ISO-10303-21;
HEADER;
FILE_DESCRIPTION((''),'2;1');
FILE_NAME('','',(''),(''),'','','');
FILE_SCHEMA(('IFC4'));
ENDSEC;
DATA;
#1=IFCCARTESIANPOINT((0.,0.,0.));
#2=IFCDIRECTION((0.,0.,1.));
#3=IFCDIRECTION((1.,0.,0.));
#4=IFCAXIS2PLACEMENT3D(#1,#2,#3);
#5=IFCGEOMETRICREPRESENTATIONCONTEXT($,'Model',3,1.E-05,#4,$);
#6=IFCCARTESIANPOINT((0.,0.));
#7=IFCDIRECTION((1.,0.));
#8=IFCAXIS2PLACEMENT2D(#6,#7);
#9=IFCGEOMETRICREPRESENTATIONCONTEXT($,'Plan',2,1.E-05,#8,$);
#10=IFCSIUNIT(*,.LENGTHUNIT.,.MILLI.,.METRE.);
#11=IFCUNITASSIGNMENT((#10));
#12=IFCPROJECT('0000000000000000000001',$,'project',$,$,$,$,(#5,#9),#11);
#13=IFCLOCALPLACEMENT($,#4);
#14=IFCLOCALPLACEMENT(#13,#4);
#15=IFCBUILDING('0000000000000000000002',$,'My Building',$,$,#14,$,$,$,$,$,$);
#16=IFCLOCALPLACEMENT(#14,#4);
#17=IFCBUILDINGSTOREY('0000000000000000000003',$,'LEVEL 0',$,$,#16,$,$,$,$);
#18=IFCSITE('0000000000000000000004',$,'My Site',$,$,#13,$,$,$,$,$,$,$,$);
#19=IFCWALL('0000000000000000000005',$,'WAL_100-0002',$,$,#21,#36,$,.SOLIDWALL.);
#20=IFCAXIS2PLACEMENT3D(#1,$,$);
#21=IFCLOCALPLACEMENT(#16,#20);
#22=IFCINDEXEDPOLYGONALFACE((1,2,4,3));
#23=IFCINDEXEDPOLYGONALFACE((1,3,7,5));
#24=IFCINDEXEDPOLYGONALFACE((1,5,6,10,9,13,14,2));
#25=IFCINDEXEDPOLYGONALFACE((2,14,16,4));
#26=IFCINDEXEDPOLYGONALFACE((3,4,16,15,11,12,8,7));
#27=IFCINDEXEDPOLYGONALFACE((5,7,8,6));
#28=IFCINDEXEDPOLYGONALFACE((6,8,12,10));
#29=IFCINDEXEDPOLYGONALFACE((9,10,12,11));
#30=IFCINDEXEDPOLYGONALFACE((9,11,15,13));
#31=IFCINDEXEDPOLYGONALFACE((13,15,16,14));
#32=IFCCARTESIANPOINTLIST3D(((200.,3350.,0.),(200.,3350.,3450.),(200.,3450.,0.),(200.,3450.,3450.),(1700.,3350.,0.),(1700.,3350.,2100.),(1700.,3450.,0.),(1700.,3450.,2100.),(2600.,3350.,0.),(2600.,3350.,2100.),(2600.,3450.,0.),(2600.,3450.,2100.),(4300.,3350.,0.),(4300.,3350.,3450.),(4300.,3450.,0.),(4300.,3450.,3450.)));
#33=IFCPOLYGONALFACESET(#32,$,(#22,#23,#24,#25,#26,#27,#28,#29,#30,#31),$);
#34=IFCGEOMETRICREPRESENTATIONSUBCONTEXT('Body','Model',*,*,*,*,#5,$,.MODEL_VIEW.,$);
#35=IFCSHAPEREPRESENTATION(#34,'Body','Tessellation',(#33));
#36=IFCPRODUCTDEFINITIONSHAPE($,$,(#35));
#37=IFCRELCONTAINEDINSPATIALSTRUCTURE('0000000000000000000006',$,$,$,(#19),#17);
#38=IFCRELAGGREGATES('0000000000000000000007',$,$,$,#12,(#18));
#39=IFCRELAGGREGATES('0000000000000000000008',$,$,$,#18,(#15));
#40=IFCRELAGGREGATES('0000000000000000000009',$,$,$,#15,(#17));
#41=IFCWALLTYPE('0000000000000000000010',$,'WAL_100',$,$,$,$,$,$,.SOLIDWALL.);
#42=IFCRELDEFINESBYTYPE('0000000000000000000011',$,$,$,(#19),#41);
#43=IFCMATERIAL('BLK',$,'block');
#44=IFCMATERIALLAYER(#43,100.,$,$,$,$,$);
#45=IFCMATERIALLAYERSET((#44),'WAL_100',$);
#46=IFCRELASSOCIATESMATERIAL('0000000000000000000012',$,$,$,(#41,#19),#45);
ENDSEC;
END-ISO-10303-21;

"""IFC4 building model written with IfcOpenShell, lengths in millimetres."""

from ifc_helpers import new_model, si_unit, frame, origin_with_axes, origin_2d_with_axis, place, context, subcontext, project, spatial, indexed_curve, outline, extrude, material, layer, layer_set, layer_usage, type_object, element, save


model = new_model("IFC4")

# Units and contexts
model_context = context("Model", 3, precision=1e-05, world=origin_with_axes())
plan_context = context("Plan", 2, precision=1e-05, world=origin_2d_with_axis())
body_context = subcontext(model_context, "Body", "Model", "MODEL_VIEW")
ifc_project = project(units=[si_unit("LENGTHUNIT", "METRE", prefix="MILLI")], contexts=[model_context, plan_context])

# Site, building, storey
site_placement = place(None, origin_with_axes())
site = spatial("IfcSite", under=ifc_project, at=site_placement, Name="My Site")
building_placement = place(site_placement, origin_with_axes())
building = spatial("IfcBuilding", under=site, at=building_placement, Name="My Building")
storey_placement = place(building_placement, origin_with_axes())
storey = spatial("IfcBuildingStorey", under=building, at=storey_placement, Name="LEVEL 0")

# Shared definitions
ifc_material_1 = material(Name="BLK", Category="block")

# Wall, opening
ifc_layer_1 = layer(ifc_material_1, 100.0)
ifc_layer_set_1 = layer_set([ifc_layer_1], Name="WAL_100")
wall_type_1 = type_object("IfcWallType", Name="WAL_100", PredefinedType="SOLIDWALL", material=ifc_layer_set_1)
ifc_layer_usage_1 = layer_usage(ifc_layer_set_1, "AXIS2", "POSITIVE", 0.0)
wall_1_placement = place(storey_placement, frame((200.0, 3350.0, 0.0), z_axis=(0.0, 0.0, 1.0), x_axis=(1.0, 0.0, 0.0)))
wall_1 = element("IfcWall", 1, at=wall_1_placement, inside=storey, type_object=wall_type_1, material=ifc_layer_usage_1, Name="WAL_100-0002", PredefinedType="SOLIDWALL", context=body_context, shape_type="SweptSolid", body=[
    extrude(outline(indexed_curve([(0.0, 0.0), (0.0, 100.0), (4100.0, 100.0), (4100.0, 0.0), (0.0, 0.0)], self_intersect=False)), origin_with_axes(), (0.0, 0.0, 1.0), 3450.0),
])
opening_1_placement = place(wall_1_placement, frame((1500.0, 0.0, 0.0), z_axis=(0.0, 0.0, 1.0), x_axis=(1.0, 0.0, 0.0)))
element("IfcOpeningElement", 2, at=opening_1_placement, cuts=wall_1, PredefinedType="OPENING", context=body_context, shape_type="SweptSolid", body=[
    extrude(outline(indexed_curve([(0.0, 0.0), (0.0, 400.0), (900.0, 400.0), (900.0, 0.0), (0.0, 0.0)], self_intersect=False)), frame((0.0, -100.0, 0.0), z_axis=(0.0, 0.0, 1.0), x_axis=(1.0, 0.0, 0.0)), (0.0, 0.0, 1.0), 2100.0),
])

save(model, "model.ifc")
